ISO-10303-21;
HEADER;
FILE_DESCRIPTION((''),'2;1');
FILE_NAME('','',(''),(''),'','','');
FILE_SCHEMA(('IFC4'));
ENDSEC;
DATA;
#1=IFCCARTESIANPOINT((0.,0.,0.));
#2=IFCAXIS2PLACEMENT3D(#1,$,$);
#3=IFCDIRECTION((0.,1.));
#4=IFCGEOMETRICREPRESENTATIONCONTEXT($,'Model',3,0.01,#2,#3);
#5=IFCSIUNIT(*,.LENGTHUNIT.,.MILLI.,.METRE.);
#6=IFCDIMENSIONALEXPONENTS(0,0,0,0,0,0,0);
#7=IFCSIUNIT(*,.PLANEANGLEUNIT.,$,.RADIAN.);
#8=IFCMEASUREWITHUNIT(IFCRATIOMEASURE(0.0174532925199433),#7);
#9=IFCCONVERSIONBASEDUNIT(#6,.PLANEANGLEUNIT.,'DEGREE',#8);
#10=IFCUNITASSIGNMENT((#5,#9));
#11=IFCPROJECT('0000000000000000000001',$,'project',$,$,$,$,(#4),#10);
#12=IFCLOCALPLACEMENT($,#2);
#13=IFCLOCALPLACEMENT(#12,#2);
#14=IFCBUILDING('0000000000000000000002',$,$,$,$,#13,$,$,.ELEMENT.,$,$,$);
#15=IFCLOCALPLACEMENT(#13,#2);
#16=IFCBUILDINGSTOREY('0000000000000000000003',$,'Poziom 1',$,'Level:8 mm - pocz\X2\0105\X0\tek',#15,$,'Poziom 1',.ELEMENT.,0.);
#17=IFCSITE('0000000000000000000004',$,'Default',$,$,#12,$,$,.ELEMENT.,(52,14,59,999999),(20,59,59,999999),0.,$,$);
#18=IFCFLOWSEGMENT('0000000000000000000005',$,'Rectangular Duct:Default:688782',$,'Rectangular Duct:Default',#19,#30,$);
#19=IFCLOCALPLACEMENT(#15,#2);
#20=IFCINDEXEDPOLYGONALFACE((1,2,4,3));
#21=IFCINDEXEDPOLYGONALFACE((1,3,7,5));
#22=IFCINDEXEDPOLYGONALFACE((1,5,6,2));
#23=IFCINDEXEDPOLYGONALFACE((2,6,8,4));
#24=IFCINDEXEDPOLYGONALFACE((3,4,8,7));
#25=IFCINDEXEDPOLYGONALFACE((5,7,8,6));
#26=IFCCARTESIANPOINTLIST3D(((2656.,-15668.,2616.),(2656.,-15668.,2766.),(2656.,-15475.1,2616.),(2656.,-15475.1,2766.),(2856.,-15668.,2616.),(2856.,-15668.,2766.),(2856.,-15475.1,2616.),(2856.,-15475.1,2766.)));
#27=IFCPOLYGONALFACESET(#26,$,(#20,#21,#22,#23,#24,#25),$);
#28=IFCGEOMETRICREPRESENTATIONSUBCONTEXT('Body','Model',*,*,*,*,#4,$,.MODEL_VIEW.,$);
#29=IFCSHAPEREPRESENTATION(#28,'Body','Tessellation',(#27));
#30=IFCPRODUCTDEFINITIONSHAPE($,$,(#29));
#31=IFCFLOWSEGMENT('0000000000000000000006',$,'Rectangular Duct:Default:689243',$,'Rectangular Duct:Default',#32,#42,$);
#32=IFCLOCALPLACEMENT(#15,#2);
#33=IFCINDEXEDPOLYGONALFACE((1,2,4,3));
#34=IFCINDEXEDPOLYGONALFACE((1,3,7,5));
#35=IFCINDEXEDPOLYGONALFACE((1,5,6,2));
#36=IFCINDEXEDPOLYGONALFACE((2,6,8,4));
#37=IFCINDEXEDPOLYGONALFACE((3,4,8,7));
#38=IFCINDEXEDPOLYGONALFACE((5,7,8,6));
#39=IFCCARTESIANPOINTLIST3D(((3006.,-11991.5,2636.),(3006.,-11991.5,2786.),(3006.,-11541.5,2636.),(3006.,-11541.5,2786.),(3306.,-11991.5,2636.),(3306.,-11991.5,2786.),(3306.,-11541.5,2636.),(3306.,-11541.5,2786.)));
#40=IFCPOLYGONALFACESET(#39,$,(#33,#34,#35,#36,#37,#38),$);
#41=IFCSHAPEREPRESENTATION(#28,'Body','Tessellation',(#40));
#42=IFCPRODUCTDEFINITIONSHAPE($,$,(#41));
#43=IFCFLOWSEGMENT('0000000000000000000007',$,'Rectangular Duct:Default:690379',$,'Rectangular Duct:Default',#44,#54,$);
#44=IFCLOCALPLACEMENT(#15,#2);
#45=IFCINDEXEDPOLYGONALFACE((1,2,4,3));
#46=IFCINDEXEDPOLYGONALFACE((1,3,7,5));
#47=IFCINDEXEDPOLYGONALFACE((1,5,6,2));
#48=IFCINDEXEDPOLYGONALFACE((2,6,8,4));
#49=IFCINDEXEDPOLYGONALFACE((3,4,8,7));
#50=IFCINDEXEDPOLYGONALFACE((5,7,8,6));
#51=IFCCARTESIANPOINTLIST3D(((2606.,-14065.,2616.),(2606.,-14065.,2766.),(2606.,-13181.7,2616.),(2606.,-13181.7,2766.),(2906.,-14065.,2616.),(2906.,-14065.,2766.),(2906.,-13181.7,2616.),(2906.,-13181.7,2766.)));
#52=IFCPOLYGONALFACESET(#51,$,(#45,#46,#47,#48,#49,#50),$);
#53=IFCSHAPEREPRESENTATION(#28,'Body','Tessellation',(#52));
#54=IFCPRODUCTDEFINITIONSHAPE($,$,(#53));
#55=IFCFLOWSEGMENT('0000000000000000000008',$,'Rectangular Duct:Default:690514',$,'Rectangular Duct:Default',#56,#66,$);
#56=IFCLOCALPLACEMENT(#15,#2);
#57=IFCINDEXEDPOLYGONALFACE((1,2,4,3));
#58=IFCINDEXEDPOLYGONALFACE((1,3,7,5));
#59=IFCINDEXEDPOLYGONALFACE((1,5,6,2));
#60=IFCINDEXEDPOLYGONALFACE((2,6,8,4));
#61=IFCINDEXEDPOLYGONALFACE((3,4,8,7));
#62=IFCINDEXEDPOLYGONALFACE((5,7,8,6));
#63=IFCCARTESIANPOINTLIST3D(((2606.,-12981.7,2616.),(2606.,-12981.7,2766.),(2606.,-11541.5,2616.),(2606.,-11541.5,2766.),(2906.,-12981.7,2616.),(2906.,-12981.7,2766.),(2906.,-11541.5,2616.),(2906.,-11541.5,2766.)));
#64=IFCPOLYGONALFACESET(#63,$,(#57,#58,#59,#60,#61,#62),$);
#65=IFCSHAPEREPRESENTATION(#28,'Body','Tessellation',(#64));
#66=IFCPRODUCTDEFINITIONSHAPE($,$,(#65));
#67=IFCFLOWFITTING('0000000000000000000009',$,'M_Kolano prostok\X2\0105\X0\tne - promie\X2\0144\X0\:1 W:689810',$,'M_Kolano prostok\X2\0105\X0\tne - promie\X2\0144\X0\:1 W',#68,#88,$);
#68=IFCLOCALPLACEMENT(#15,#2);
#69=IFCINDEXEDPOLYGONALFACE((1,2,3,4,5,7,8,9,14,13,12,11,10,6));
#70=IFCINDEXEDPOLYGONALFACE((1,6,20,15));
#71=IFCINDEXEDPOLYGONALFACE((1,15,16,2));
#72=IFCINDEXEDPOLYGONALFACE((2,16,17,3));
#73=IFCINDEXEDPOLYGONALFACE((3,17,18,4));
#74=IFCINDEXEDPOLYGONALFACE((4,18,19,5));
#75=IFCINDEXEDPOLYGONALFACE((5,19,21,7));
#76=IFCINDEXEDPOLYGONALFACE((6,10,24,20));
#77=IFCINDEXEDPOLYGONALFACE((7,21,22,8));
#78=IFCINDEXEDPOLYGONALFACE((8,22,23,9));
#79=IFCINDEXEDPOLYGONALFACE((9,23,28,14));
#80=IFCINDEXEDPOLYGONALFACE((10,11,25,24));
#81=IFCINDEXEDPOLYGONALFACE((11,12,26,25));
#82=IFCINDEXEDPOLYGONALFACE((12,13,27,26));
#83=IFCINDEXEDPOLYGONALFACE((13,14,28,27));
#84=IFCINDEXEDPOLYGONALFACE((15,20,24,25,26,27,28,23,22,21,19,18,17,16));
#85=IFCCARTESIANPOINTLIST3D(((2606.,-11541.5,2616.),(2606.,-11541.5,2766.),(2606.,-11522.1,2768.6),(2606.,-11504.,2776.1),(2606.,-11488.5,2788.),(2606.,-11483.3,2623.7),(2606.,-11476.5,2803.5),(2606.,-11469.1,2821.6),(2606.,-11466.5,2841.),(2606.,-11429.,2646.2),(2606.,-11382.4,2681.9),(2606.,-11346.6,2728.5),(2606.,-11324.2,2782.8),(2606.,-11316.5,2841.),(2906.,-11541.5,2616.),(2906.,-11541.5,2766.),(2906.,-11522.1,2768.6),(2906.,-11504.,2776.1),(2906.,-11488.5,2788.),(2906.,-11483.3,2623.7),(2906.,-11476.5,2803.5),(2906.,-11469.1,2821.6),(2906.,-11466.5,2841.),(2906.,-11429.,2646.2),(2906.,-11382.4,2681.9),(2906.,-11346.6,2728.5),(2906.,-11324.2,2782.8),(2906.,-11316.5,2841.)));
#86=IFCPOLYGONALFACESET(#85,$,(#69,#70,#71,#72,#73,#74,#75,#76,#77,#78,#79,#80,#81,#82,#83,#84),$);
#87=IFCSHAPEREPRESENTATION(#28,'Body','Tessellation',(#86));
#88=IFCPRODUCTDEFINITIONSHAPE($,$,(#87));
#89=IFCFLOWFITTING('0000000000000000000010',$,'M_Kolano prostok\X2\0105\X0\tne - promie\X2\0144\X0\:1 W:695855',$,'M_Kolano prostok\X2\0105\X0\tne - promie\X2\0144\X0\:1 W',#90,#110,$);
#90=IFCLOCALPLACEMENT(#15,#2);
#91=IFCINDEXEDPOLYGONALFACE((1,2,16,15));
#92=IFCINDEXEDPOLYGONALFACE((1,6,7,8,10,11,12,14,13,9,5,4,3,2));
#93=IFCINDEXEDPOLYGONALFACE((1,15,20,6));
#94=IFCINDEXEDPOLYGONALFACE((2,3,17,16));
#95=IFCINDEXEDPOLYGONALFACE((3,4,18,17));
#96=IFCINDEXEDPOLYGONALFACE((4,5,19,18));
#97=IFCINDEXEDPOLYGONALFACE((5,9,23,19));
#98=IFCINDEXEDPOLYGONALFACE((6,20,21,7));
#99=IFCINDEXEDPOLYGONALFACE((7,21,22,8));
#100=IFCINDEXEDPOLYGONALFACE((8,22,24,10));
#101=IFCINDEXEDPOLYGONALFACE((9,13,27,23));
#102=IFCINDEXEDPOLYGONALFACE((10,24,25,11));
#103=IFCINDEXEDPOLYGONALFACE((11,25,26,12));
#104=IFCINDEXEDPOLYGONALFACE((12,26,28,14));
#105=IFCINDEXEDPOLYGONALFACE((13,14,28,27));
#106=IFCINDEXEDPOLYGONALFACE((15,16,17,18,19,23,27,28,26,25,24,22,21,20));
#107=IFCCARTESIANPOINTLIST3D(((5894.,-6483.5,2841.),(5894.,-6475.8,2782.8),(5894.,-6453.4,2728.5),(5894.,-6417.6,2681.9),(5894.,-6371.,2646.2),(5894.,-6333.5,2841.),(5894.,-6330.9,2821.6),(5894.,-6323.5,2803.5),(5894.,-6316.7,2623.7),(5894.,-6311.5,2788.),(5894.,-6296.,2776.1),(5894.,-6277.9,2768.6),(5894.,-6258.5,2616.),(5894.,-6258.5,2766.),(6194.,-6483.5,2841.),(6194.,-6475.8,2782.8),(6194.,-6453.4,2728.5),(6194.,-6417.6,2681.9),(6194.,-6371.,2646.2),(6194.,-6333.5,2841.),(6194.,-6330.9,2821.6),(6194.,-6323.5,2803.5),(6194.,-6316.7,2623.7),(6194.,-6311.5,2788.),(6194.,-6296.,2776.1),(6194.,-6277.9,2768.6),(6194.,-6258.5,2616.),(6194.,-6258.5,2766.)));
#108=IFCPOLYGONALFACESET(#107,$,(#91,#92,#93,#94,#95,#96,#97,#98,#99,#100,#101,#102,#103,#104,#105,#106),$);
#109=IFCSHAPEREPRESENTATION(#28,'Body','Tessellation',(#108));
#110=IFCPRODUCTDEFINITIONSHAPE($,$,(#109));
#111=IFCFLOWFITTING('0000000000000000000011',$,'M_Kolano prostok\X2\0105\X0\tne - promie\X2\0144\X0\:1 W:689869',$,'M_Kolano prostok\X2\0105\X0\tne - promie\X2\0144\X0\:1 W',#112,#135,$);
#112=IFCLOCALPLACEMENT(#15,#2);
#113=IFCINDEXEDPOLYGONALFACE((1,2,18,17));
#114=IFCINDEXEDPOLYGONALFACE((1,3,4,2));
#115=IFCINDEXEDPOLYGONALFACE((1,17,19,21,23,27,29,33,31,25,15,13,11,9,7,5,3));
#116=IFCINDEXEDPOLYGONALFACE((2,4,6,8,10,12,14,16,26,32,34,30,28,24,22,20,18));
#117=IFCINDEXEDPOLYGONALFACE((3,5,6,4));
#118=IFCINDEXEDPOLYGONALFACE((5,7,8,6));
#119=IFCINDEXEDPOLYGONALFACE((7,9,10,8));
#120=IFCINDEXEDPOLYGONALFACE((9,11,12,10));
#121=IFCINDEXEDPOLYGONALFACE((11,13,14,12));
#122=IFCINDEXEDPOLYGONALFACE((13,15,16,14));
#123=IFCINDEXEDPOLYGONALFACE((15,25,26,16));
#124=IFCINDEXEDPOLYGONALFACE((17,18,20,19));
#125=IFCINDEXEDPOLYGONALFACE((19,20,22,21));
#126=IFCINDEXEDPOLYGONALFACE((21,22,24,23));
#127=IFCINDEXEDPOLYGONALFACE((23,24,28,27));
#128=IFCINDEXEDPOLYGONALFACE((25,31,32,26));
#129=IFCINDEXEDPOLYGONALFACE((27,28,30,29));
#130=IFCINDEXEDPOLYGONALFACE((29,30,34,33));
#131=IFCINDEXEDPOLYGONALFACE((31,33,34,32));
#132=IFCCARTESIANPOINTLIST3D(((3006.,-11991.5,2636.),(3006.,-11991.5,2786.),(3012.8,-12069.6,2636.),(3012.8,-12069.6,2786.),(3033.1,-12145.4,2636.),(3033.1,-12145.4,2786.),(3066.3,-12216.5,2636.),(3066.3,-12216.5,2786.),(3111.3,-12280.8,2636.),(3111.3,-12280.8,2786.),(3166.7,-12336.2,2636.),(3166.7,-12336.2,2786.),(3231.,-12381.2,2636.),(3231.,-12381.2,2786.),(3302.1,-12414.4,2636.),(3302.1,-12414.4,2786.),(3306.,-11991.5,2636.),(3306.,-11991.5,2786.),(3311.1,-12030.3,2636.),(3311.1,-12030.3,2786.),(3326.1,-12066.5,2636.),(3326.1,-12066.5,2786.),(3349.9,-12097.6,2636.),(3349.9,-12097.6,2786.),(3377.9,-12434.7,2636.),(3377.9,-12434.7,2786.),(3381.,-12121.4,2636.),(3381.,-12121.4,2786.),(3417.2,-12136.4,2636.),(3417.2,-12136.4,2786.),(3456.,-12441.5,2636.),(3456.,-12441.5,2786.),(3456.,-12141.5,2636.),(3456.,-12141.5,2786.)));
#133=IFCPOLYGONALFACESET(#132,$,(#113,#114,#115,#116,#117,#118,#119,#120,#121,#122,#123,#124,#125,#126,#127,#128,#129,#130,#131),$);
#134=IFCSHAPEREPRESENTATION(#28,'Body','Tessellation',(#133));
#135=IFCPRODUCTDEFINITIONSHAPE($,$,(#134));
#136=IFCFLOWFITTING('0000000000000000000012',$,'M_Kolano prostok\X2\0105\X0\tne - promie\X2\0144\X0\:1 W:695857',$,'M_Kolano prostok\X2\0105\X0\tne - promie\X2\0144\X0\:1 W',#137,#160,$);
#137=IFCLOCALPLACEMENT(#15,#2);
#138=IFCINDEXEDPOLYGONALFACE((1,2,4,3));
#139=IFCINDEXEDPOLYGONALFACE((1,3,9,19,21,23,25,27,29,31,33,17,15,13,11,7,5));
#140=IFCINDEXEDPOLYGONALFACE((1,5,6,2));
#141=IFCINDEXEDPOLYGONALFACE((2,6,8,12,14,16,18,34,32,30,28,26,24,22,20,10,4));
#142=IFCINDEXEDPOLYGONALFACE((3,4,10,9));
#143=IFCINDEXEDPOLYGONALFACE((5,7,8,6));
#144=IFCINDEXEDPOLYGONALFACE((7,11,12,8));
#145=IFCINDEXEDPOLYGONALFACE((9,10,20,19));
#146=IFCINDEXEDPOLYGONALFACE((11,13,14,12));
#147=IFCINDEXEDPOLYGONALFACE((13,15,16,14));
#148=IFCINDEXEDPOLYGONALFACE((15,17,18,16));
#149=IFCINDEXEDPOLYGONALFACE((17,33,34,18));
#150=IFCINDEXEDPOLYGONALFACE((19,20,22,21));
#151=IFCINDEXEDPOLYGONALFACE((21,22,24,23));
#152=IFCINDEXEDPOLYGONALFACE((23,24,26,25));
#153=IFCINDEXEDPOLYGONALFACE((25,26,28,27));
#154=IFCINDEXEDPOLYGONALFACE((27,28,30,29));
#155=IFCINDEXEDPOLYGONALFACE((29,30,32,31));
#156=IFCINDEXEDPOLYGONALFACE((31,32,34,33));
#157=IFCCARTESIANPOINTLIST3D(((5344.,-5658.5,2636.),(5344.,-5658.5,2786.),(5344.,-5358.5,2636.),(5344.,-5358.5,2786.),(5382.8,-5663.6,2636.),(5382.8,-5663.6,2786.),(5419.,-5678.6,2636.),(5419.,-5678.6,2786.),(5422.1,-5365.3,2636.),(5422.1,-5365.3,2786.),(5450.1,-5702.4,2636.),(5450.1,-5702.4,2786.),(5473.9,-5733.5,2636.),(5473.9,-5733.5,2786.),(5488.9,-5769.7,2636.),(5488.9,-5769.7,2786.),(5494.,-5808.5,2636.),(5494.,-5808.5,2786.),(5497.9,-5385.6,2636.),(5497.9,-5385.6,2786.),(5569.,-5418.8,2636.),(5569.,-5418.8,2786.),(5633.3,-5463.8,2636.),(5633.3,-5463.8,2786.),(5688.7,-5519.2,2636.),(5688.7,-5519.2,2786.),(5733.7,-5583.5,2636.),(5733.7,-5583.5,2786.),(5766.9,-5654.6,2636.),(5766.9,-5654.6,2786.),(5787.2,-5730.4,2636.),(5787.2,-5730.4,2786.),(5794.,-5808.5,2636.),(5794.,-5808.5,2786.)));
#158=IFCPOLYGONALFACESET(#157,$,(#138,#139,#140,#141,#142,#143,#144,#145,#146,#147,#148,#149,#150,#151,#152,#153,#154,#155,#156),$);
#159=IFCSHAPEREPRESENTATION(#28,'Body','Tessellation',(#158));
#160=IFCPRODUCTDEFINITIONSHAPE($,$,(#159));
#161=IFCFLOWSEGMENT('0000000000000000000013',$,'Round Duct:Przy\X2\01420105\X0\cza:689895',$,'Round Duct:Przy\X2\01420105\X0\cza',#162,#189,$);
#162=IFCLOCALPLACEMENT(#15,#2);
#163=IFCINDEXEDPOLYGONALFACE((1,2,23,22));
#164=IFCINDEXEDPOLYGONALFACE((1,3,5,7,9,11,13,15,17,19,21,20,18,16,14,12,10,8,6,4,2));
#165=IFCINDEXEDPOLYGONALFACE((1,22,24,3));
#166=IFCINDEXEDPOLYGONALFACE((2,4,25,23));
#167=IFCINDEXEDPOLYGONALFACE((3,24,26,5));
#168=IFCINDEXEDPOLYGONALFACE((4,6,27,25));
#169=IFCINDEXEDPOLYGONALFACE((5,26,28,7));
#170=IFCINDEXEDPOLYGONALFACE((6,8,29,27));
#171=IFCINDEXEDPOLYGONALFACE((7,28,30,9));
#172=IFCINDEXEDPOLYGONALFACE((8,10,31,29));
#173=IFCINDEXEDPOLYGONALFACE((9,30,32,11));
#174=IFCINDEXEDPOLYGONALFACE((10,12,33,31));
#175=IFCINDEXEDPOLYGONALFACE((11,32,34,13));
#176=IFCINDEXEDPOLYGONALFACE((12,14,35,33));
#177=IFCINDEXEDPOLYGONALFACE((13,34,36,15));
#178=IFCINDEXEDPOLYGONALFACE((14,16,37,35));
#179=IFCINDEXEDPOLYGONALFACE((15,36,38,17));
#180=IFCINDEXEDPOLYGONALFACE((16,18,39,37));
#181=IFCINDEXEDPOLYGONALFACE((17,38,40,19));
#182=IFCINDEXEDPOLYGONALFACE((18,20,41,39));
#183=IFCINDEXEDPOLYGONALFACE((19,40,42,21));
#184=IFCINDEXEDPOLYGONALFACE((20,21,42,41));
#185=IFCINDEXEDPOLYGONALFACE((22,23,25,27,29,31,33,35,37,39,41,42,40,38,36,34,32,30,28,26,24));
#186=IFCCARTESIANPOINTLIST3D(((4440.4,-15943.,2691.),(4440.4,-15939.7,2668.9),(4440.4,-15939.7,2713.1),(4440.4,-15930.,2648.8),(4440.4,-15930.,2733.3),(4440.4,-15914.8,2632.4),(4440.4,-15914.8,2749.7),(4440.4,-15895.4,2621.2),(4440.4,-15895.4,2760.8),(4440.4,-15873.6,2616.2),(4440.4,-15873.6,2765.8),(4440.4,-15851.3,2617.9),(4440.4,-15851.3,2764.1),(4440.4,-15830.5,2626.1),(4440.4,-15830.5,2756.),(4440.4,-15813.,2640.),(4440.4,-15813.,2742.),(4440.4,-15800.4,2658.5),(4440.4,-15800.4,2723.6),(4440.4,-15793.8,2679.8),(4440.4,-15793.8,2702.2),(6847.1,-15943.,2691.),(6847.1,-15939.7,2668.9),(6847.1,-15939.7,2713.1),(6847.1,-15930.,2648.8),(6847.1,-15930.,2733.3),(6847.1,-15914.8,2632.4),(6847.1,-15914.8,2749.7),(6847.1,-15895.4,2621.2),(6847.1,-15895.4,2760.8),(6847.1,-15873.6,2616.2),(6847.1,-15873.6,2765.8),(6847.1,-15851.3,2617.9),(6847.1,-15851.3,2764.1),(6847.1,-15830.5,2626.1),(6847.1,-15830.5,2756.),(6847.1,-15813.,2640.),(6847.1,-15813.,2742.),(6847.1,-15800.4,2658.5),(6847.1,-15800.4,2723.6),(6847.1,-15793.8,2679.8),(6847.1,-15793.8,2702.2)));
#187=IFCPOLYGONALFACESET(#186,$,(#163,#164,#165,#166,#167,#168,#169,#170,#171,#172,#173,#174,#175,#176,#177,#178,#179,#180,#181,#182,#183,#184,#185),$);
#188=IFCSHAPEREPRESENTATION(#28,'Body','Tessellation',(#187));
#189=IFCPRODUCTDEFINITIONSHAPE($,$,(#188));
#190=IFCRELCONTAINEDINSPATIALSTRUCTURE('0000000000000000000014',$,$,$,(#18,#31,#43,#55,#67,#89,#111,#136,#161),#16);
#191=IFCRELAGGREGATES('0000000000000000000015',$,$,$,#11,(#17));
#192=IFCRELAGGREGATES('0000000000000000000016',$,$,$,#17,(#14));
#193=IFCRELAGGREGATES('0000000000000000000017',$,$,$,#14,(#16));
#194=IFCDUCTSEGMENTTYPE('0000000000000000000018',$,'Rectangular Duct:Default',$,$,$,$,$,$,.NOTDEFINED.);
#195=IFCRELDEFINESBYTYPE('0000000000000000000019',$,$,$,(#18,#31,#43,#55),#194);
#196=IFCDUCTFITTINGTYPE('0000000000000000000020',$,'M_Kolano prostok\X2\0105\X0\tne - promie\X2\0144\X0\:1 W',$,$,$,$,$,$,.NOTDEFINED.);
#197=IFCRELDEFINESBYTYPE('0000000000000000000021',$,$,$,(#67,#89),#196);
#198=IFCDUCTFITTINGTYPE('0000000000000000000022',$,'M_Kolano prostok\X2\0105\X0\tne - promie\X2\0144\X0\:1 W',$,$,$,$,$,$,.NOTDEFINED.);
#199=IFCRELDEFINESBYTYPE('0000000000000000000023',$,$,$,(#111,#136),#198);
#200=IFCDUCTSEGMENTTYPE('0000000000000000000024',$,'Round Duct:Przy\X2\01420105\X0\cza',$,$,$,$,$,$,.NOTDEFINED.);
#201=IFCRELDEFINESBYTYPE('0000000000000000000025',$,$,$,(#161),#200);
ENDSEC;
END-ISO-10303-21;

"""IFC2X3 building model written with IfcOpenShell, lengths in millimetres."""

from ifc_helpers import new_model, entity, si_unit, converted_unit, direction, frame, frame_2d, origin, origin_2d_with_axis, place, context, subcontext, project, spatial, polyline, circle_curve, parameter, trimmed, segment, composite_curve, rectangle, circle, outline, extrude, source, transform, mapped, type_object, type_shapes, element, save


model = new_model("IFC2X3")

# Units and contexts
model_context = context("Model", 3, precision=0.01, world=origin(), true_north=direction((0.0, 1.0)))
body_context = subcontext(model_context, "Body", "Model", "MODEL_VIEW")
ifc_project = project(units=[si_unit("LENGTHUNIT", "METRE", prefix="MILLI"), converted_unit("PLANEANGLEUNIT", "DEGREE", entity("IfcRatioMeasure", 0.0174532925199433), si_unit("PLANEANGLEUNIT", "RADIAN"), dimensions=[0, 0, 0, 0, 0, 0, 0])], contexts=[model_context])

# Site, building, storey
site_placement = place(None, origin())
site = spatial("IfcSite", under=ifc_project, at=site_placement, Name="Default", CompositionType="ELEMENT", RefLatitude=(52, 14, 59, 999999), RefLongitude=(20, 59, 59, 999999), RefElevation=0.0)
building_placement = place(site_placement, origin())
building = spatial("IfcBuilding", under=site, at=building_placement, CompositionType="ELEMENT")
storey_placement = place(building_placement, origin())
storey = spatial("IfcBuildingStorey", under=building, at=storey_placement, Name="Poziom 1", ObjectType="Level:8 mm - początek", LongName="Poziom 1", CompositionType="ELEMENT", Elevation=0.0)

# Flow segments
duct_segment_type_1 = type_object("IfcDuctSegmentType", Name="Rectangular Duct:Default", PredefinedType="NOTDEFINED")
flow_segment_1_placement = place(storey_placement, origin())
element("IfcFlowSegment", 1, at=flow_segment_1_placement, inside=storey, type_object=duct_segment_type_1, Name="Rectangular Duct:Default:688782", ObjectType="Rectangular Duct:Default", context=body_context, shape_type="SweptSolid", body=[
    extrude(rectangle(XDim=192.9, YDim=200.0, at=frame_2d((0.0, 0.0), x_axis=(1.0, 0.0))), frame((2756.0, -15571.6, 2616.0), z_axis=(0.0, 0.0, 1.0), x_axis=(0.0, -1.0, 0.0)), (0.0, 0.0, 1.0), 150.0),
])
flow_segment_2_placement = place(storey_placement, origin())
element("IfcFlowSegment", 2, at=flow_segment_2_placement, inside=storey, type_object=duct_segment_type_1, Name="Rectangular Duct:Default:689243", ObjectType="Rectangular Duct:Default", context=body_context, shape_type="SweptSolid", body=[
    extrude(rectangle(XDim=450.0, YDim=300.0, at=origin_2d_with_axis()), frame((3156.0, -11766.5, 2636.0), z_axis=(0.0, 0.0, 1.0), x_axis=(0.0, -1.0, 0.0)), (0.0, 0.0, 1.0), 150.0),
])
flow_segment_3_placement = place(storey_placement, origin())
element("IfcFlowSegment", 3, at=flow_segment_3_placement, inside=storey, type_object=duct_segment_type_1, Name="Rectangular Duct:Default:690379", ObjectType="Rectangular Duct:Default", context=body_context, shape_type="SweptSolid", body=[
    extrude(rectangle(XDim=883.3, YDim=300.0, at=frame_2d((0.0, 0.0), x_axis=(1.0, 0.0))), frame((2756.0, -13623.3, 2616.0), z_axis=(0.0, 0.0, 1.0), x_axis=(0.0, -1.0, 0.0)), (0.0, 0.0, 1.0), 150.0),
])
flow_segment_4_placement = place(storey_placement, origin())
element("IfcFlowSegment", 4, at=flow_segment_4_placement, inside=storey, type_object=duct_segment_type_1, Name="Rectangular Duct:Default:690514", ObjectType="Rectangular Duct:Default", context=body_context, shape_type="SweptSolid", body=[
    extrude(rectangle(XDim=1440.2, YDim=300.0, at=origin_2d_with_axis()), frame((2756.0, -12261.6, 2616.0), z_axis=(0.0, 0.0, 1.0), x_axis=(0.0, -1.0, 0.0)), (0.0, 0.0, 1.0), 150.0),
])

# Flow fittings
duct_fitting_type_1 = type_object("IfcDuctFittingType", Name="M_Kolano prostokątne - promień:1 W", PredefinedType="NOTDEFINED")
shared_shape_1 = source(origin(), body_context, "Body", "SweptSolid", [
    extrude(outline(composite_curve([segment(polyline([(-150.0, -75.0), (0.0, -75.0)]), True, "CONTINUOUS"), segment(trimmed(circle_curve(frame_2d((75.0, -75.0), x_axis=(0.0, 1.0)), 75.0), [parameter(0.0)], [parameter(90.0)], True, "PARAMETER"), False, "CONTINUOUS"), segment(polyline([(75.0, 0.0), (75.0, 150.0)]), True, "CONTINUOUS"), segment(trimmed(circle_curve(frame_2d((75.0, -75.0), x_axis=(0.0, 1.0)), 225.0), [parameter(0.0)], [parameter(90.0)], True, "PARAMETER"), True, "CONTINUOUS")], self_intersect=False)), frame((-75.0, 75.0, -150.0), z_axis=(0.0, 0.0, 1.0), x_axis=(-1.0, 0.0, 0.0)), (0.0, 0.0, 1.0), 300.0),
])
type_shapes(duct_fitting_type_1, [shared_shape_1])
for number, where, z_axis, x_axis, name in (
    (5, (2756.0, -11391.5, 2691.0), (1.0, 0.0, 0.0), (0.0, 1.0, 0.0), "M_Kolano prostokątne - promień:1 W:689810"),
    (6, (6044.0, -6408.5, 2691.0), (-1.0, 0.0, 0.0), (0.0, -1.0, 0.0), "M_Kolano prostokątne - promień:1 W:695855"),
):
    element("IfcFlowFitting", number, at=place(storey_placement, frame(where, z_axis=z_axis, x_axis=x_axis)), inside=storey, type_object=duct_fitting_type_1, Name=name, ObjectType="M_Kolano prostokątne - promień:1 W", context=body_context, shape_type="MappedRepresentation", body=[
        mapped(shared_shape_1, transform((0.0, 0.0, 0.0), scale=1.0)),
    ])
duct_fitting_type_2 = type_object("IfcDuctFittingType", Name="M_Kolano prostokątne - promień:1 W", PredefinedType="NOTDEFINED")
shared_shape_2 = source(origin(), body_context, "Body", "SweptSolid", [
    extrude(outline(composite_curve([segment(polyline([(-300.0, -150.0), (0.0, -150.0)]), True, "CONTINUOUS"), segment(trimmed(circle_curve(frame_2d((150.0, -150.0), x_axis=(0.0, 1.0)), 150.0), [parameter(0.0)], [parameter(90.0)], True, "PARAMETER"), False, "CONTINUOUS"), segment(polyline([(150.0, 0.0), (150.0, 300.0)]), True, "CONTINUOUS"), segment(trimmed(circle_curve(frame_2d((150.0, -150.0), x_axis=(0.0, 1.0)), 450.0), [parameter(0.0)], [parameter(90.0)], True, "PARAMETER"), True, "CONTINUOUS")], self_intersect=False)), frame((-150.0, 150.0, -75.0), z_axis=(0.0, 0.0, 1.0), x_axis=(-1.0, 0.0, 0.0)), (0.0, 0.0, 1.0), 150.0),
])
type_shapes(duct_fitting_type_2, [shared_shape_2])
for number, where, z_axis, x_axis, name in (
    (7, (3156.0, -12291.5, 2711.0), (0.0, 0.0, 1.0), (0.0, -1.0, 0.0), "M_Kolano prostokątne - promień:1 W:689869"),
    (8, (5644.0, -5508.5, 2711.0), (0.0, 0.0, 1.0), (0.0, 1.0, 0.0), "M_Kolano prostokątne - promień:1 W:695857"),
):
    element("IfcFlowFitting", number, at=place(storey_placement, frame(where, z_axis=z_axis, x_axis=x_axis)), inside=storey, type_object=duct_fitting_type_2, Name=name, ObjectType="M_Kolano prostokątne - promień:1 W", context=body_context, shape_type="MappedRepresentation", body=[
        mapped(shared_shape_2, transform((0.0, 0.0, 0.0), scale=1.0)),
    ])

# Flow segment
duct_segment_type_2 = type_object("IfcDuctSegmentType", Name="Round Duct:Przyłącza", PredefinedType="NOTDEFINED")
flow_segment_5_placement = place(storey_placement, origin())
element("IfcFlowSegment", 9, at=flow_segment_5_placement, inside=storey, type_object=duct_segment_type_2, Name="Round Duct:Przyłącza:689895", ObjectType="Round Duct:Przyłącza", context=body_context, shape_type="SweptSolid", body=[
    extrude(circle(Radius=75.0, at=origin_2d_with_axis()), frame((4440.4, -15868.0, 2691.0), z_axis=(1.0, 0.0, 0.0), x_axis=(0.0, -1.0, 0.0)), (0.0, 0.0, 1.0), 2406.7),
])

save(model, "model.ifc")
